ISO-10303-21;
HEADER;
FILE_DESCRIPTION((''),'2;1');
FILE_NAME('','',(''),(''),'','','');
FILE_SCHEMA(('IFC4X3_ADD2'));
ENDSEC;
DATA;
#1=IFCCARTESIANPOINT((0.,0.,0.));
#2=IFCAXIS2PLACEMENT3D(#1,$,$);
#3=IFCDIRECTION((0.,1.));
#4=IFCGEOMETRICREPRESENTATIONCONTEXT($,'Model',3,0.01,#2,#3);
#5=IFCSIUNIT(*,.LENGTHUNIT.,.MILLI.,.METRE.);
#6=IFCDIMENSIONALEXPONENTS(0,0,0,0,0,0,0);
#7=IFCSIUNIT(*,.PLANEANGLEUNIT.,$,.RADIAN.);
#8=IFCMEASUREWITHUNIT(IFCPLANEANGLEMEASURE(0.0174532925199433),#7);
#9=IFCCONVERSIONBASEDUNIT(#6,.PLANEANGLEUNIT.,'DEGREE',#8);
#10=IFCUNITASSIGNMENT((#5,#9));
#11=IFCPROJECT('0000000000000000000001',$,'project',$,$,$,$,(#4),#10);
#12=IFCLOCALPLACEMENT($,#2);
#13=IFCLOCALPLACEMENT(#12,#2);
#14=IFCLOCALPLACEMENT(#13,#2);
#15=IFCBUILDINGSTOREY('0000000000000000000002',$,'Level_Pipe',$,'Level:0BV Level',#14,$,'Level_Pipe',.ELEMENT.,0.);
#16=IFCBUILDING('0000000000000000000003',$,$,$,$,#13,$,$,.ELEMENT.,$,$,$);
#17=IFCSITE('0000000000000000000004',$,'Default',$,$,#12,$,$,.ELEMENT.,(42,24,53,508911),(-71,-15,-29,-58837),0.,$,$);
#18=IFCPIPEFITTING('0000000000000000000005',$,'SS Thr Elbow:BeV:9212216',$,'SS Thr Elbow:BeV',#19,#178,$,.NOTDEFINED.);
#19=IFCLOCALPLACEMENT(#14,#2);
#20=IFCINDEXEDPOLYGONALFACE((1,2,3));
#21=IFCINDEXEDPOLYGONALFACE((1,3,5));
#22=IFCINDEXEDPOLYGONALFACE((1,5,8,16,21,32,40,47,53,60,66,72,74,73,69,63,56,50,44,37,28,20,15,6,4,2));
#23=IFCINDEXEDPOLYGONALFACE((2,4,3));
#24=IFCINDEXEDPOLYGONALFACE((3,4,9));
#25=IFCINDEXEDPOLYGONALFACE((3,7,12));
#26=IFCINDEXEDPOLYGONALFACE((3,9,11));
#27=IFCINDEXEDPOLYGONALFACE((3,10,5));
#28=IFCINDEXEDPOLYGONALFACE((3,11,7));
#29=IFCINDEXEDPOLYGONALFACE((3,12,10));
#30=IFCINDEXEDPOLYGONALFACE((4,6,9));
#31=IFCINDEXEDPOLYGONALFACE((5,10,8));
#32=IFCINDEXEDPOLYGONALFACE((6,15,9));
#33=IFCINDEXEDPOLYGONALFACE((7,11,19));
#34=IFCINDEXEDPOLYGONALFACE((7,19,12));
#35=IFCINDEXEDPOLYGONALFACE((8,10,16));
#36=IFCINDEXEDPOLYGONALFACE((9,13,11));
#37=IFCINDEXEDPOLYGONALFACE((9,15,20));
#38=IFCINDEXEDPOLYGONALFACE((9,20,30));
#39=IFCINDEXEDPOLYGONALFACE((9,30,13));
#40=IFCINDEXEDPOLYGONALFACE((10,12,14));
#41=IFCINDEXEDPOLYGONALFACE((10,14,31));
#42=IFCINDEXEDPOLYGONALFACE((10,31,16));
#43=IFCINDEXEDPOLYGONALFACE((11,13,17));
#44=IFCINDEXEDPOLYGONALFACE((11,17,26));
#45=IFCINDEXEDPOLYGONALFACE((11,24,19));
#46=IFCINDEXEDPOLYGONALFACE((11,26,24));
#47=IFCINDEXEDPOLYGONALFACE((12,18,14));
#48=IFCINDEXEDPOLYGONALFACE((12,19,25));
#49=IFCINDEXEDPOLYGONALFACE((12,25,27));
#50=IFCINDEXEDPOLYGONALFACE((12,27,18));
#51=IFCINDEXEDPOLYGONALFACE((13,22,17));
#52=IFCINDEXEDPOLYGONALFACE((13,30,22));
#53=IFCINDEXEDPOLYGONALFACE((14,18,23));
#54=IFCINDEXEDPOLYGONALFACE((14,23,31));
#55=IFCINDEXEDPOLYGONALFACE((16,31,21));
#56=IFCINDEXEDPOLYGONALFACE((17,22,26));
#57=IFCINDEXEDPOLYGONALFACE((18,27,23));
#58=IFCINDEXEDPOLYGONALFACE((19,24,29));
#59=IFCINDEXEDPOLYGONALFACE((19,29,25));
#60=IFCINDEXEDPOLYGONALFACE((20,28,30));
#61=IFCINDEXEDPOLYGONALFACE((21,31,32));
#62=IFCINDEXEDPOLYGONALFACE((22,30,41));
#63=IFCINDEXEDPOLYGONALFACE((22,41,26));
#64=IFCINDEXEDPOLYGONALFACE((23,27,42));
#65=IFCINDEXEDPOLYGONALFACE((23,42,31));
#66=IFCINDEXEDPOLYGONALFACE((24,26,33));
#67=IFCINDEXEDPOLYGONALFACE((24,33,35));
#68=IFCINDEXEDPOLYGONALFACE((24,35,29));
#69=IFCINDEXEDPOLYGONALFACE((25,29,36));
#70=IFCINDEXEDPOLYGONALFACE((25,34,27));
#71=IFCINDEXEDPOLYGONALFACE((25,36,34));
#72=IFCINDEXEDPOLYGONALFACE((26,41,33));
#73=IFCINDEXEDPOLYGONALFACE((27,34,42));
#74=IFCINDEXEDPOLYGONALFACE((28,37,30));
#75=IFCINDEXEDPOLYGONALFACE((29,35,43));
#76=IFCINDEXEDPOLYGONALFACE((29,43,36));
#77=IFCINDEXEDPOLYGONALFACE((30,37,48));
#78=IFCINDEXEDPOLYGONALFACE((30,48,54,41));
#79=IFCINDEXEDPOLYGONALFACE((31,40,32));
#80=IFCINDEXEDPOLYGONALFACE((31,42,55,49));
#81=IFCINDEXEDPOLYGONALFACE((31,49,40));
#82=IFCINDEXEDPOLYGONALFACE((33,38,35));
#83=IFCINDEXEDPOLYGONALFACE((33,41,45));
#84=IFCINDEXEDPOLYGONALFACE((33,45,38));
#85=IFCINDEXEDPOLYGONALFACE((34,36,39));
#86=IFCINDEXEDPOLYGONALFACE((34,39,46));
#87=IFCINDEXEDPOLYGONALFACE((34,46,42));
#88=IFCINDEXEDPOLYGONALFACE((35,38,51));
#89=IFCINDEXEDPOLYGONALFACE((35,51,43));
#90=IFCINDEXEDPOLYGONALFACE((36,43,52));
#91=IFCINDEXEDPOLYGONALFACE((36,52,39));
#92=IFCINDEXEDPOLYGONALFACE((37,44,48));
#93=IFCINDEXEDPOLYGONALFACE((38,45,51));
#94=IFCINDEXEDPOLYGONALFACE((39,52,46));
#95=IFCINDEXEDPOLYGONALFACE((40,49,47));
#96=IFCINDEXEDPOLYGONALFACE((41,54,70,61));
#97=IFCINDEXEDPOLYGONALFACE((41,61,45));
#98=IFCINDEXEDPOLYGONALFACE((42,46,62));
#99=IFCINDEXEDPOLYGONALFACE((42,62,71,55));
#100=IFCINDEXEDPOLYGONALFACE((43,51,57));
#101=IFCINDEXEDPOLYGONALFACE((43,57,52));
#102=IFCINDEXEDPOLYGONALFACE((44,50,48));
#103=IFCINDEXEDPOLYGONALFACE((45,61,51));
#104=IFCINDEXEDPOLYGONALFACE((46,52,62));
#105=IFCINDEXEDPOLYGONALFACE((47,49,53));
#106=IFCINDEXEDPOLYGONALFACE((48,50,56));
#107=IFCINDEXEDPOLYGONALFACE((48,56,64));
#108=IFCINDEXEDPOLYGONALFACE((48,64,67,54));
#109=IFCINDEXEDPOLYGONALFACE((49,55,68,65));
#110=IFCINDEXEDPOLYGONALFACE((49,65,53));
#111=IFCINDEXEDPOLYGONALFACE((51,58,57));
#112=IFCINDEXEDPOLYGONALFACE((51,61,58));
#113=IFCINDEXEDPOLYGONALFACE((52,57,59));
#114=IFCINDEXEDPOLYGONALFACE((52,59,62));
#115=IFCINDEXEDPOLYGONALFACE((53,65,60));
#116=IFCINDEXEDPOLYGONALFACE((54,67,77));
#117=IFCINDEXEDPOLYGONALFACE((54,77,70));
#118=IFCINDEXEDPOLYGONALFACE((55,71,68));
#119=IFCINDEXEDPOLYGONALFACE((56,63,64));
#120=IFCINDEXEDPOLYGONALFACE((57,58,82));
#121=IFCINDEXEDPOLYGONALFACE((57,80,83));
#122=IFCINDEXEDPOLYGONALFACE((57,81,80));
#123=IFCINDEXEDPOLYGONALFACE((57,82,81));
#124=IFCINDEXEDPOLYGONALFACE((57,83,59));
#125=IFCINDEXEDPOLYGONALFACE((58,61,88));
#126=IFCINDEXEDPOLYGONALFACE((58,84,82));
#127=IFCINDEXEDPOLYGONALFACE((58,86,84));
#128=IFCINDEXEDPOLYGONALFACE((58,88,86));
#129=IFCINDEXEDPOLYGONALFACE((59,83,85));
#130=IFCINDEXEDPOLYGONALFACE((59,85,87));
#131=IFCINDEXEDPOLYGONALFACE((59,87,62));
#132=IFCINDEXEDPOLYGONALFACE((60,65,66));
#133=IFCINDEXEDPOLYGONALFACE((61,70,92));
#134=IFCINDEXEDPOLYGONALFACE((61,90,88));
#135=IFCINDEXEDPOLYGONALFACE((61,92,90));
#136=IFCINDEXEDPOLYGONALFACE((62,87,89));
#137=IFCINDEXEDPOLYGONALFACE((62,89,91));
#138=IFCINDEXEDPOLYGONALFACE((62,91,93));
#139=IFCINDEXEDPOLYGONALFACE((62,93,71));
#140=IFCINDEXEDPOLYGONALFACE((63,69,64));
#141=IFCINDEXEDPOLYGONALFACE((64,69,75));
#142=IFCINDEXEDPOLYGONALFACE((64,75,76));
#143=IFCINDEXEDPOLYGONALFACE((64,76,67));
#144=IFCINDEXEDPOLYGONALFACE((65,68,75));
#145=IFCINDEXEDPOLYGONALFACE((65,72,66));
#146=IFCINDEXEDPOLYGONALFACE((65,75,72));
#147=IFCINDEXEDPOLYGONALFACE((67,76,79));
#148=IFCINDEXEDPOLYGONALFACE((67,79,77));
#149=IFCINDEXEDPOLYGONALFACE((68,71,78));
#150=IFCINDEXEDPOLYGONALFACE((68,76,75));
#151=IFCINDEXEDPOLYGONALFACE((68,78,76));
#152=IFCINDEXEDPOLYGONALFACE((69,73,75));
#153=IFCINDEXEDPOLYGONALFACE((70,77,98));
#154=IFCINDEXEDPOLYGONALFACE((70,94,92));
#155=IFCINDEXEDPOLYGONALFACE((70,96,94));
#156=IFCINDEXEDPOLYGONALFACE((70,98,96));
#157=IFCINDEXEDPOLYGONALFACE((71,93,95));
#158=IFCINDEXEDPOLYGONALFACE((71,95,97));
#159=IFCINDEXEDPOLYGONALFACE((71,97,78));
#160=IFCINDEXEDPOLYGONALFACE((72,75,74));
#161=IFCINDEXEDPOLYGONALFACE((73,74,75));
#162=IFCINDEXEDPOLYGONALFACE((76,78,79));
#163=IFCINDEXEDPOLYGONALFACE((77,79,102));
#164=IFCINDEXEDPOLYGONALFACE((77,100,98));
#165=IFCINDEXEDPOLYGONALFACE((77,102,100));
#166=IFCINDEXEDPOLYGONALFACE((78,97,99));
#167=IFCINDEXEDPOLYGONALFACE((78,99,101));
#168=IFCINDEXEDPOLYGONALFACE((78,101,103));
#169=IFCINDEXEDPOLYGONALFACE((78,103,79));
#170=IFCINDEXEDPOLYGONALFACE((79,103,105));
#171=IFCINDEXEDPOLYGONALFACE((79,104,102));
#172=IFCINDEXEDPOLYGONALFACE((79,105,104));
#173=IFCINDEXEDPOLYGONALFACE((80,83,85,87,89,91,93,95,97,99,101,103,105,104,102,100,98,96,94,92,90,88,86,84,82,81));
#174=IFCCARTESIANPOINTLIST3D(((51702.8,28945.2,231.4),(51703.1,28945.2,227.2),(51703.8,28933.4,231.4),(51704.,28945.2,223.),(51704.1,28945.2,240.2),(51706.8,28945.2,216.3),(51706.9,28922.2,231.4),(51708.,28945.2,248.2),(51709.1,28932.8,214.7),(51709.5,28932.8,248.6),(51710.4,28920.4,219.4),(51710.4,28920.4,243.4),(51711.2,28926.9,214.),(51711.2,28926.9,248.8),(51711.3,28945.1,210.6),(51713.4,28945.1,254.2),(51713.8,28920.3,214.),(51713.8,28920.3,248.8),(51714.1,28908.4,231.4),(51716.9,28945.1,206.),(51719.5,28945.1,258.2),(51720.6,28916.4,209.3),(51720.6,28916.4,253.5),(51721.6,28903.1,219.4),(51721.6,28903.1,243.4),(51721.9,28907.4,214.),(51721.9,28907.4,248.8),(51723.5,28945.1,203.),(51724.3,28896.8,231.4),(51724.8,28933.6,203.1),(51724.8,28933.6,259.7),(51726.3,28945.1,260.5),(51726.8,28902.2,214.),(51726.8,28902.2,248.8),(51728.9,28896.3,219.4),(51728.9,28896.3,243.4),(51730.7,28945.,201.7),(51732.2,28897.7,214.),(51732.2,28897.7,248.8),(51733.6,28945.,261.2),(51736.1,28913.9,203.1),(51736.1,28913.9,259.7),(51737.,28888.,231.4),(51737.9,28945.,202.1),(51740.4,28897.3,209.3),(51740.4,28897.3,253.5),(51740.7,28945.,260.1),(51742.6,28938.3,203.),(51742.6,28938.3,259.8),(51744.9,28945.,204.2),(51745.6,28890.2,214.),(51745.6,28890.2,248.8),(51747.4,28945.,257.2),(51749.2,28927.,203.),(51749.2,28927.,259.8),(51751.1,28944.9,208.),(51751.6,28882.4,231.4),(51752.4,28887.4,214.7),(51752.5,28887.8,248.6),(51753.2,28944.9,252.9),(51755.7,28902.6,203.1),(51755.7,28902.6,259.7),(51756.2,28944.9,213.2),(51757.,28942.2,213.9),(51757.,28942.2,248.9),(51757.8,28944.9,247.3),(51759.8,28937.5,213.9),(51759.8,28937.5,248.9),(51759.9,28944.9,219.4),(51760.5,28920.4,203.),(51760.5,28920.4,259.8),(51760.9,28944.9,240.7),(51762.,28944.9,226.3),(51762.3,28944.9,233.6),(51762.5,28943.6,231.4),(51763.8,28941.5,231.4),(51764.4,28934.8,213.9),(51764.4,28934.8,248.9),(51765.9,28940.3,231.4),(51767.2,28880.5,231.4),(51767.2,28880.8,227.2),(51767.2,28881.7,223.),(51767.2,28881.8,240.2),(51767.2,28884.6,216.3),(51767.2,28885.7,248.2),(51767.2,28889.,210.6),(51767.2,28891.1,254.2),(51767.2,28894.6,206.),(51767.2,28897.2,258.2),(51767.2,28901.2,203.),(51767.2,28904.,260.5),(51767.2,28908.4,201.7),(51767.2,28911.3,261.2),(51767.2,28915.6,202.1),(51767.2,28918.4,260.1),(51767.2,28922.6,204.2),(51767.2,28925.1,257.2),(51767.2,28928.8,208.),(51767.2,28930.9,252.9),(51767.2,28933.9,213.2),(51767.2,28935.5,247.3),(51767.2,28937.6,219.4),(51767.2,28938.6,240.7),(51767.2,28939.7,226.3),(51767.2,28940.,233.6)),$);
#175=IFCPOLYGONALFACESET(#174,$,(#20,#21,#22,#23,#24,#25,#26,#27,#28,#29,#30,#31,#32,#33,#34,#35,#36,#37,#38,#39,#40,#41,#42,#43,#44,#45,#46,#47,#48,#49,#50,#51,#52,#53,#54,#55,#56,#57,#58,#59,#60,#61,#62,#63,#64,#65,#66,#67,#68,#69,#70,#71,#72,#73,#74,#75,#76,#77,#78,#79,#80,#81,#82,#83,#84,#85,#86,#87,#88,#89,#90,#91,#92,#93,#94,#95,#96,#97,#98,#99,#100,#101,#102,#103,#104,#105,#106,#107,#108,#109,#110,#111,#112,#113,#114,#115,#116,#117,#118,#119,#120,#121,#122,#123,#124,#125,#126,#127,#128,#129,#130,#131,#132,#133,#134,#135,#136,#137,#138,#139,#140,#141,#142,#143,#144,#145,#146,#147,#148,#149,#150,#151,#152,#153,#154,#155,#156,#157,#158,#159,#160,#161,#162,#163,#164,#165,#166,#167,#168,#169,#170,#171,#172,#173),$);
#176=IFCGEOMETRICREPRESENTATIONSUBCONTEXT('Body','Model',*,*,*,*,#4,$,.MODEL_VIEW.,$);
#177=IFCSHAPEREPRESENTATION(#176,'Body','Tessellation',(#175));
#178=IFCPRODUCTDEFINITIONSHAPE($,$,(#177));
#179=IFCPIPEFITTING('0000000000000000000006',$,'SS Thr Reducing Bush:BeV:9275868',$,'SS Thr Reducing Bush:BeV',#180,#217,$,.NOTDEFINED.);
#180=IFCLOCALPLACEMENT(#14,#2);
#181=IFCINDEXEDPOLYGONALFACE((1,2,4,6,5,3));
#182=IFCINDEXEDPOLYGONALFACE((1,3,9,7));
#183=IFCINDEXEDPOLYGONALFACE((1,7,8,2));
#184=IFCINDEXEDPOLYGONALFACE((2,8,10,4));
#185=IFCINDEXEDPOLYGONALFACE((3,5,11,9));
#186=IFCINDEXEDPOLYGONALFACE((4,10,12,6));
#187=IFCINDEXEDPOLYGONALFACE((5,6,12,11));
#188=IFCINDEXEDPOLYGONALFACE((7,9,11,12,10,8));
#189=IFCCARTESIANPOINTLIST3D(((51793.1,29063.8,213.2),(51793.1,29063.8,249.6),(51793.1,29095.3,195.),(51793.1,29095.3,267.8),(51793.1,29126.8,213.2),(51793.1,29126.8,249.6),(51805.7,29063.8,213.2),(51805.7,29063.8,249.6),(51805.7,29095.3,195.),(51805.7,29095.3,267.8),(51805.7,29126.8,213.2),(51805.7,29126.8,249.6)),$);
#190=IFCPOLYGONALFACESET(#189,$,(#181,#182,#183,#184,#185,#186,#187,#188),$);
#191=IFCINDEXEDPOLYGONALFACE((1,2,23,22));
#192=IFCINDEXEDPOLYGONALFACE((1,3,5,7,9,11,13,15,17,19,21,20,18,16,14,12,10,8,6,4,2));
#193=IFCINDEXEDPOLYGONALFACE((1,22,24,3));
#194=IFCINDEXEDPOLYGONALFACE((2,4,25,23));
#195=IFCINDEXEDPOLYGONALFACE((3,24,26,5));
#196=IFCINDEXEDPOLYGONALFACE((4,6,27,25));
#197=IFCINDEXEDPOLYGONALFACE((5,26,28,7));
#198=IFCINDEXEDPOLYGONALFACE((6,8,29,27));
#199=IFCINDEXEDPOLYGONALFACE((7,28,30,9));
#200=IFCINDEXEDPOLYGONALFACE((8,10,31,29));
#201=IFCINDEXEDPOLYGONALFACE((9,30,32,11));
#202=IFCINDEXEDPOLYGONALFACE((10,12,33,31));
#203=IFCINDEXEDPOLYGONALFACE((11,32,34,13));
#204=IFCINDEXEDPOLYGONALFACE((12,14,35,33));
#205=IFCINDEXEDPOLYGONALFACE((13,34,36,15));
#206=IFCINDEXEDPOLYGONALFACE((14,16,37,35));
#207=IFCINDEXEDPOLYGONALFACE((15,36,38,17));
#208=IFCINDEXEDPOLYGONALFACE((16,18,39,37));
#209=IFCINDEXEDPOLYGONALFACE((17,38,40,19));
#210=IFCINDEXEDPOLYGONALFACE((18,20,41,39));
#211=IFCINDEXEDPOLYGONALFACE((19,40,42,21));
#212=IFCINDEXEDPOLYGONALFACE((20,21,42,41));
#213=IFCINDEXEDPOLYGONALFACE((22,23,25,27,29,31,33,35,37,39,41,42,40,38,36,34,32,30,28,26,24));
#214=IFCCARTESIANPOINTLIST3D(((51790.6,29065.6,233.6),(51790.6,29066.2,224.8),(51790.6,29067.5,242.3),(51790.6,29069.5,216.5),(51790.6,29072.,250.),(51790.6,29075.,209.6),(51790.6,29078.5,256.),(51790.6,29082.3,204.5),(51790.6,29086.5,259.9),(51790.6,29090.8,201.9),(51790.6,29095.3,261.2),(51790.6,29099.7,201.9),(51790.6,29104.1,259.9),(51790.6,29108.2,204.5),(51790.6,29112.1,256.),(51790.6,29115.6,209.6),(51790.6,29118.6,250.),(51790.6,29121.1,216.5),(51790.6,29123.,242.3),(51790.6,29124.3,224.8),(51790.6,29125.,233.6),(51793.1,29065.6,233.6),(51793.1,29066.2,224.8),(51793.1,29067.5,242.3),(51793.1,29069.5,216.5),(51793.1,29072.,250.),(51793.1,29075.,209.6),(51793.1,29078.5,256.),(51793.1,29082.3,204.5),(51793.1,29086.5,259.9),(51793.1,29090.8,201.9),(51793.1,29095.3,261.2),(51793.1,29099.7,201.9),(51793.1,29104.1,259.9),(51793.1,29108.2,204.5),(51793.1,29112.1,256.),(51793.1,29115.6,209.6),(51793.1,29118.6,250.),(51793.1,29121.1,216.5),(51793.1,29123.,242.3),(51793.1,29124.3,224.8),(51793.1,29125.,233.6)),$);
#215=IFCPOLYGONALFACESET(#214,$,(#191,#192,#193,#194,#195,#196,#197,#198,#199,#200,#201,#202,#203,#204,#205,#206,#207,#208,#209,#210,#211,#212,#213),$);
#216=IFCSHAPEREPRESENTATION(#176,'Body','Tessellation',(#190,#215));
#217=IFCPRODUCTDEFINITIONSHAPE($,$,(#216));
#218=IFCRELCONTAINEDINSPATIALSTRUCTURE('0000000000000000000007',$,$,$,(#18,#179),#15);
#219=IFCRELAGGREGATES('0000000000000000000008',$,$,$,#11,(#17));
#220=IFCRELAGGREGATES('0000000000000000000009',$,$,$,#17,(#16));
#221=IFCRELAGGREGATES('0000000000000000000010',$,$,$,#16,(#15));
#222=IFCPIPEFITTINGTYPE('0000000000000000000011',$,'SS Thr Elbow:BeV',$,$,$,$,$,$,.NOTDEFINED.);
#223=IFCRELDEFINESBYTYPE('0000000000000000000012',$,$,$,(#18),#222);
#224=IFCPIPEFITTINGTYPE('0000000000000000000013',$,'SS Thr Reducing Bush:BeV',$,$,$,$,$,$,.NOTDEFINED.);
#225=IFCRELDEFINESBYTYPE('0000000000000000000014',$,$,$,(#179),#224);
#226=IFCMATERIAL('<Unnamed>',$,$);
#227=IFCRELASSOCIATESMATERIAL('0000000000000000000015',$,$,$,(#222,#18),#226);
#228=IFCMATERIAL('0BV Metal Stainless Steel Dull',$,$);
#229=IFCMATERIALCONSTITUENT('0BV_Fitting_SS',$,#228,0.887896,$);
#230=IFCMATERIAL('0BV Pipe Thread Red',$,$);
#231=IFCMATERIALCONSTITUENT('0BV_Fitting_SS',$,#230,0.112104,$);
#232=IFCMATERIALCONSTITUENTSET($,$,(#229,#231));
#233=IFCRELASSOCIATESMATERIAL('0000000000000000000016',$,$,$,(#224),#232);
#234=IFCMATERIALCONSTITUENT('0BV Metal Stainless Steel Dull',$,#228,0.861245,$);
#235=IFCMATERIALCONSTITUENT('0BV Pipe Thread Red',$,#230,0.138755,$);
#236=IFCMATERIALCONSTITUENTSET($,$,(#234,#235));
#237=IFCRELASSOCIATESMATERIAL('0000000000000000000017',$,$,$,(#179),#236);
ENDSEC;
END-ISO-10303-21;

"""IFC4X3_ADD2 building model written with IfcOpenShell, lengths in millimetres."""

from ifc_helpers import new_model, entity, si_unit, converted_unit, direction, frame, frame_2d, origin, place, context, subcontext, project, spatial, polyline, circle, outline, extrude, source, transform, mapped, material, constituent, constituent_set, type_object, type_shapes, element, save


model = new_model("IFC4X3_ADD2")

# Units and contexts
model_context = context("Model", 3, precision=0.01, world=origin(), true_north=direction((0.0, 1.0)))
body_context = subcontext(model_context, "Body", "Model", "MODEL_VIEW")
ifc_project = project(units=[si_unit("LENGTHUNIT", "METRE", prefix="MILLI"), converted_unit("PLANEANGLEUNIT", "DEGREE", entity("IfcPlaneAngleMeasure", 0.0174532925199433), si_unit("PLANEANGLEUNIT", "RADIAN"), dimensions=[0, 0, 0, 0, 0, 0, 0])], contexts=[model_context])

# Site, building, storey
site_placement = place(None, origin())
site = spatial("IfcSite", under=ifc_project, at=site_placement, Name="Default", CompositionType="ELEMENT", RefLatitude=(42, 24, 53, 508911), RefLongitude=(-71, -15, -29, -58837), RefElevation=0.0)
building_placement = place(site_placement, origin())
building = spatial("IfcBuilding", under=site, at=building_placement, CompositionType="ELEMENT")
storey_placement = place(building_placement, origin())
storey = spatial("IfcBuildingStorey", under=building, at=storey_placement, Name="Level_Pipe", ObjectType="Level:0BV Level", LongName="Level_Pipe", CompositionType="ELEMENT", Elevation=0.0)

# Shared definitions
ifc_material_1 = material(Name="0BV Metal Stainless Steel Dull")
ifc_material_2 = material(Name="0BV Pipe Thread Red")
ifc_material_3 = material(Name="<Unnamed>")

# Pipe fittings
pipe_fitting_type_1 = type_object("IfcPipeFittingType", Name="SS Thr Elbow:BeV", PredefinedType="NOTDEFINED", material=ifc_material_3)
trimmed_curve = entity("IfcTrimmedCurve", entity("IfcCircle", entity("IfcAxis2Placement2D", entity("IfcCartesianPoint", [-4.8, 0.0]), entity("IfcDirection", [0.0, 1.0])), 4.8), [entity("IfcParameterValue", 270.0)], [entity("IfcParameterValue", 0.0)], True, "PARAMETER")
shared_shape_1 = source(origin(), body_context, "Body", "AdvancedSweptSolid", [
    entity("IfcSurfaceCurveSweptAreaSolid", entity("IfcCircleProfileDef", "AREA", None, entity("IfcAxis2Placement2D", entity("IfcCartesianPoint", [29.8, 0.0]), entity("IfcDirection", [1.0, 0.0])), 29.8), entity("IfcAxis2Placement3D", entity("IfcCartesianPoint", [-29.8, 34.6, 0.0]), entity("IfcDirection", [0.0, 0.0, -1.0]), entity("IfcDirection", [1.0, 0.0, 0.0])), trimmed_curve, entity("IfcParameterValue", 0.0), entity("IfcParameterValue", 90.0), entity("IfcSurfaceOfLinearExtrusion", entity("IfcArbitraryOpenProfileDef", "CURVE", None, trimmed_curve), entity("IfcAxis2Placement3D", entity("IfcCartesianPoint", [0.0, 0.0, -304.8])), entity("IfcDirection", [0.0, 0.0, 1.0]), 1.0)),
])
type_shapes(pipe_fitting_type_1, [shared_shape_1])
pipe_fitting_1_placement = place(storey_placement, frame((51732.6, 28910.3, 231.4), z_axis=(0.0, -0.000012, 1.0), x_axis=(0.0, -1.0, -0.000012)))
element("IfcPipeFitting", 1, at=pipe_fitting_1_placement, inside=storey, type_object=pipe_fitting_type_1, material=ifc_material_3, Name="SS Thr Elbow:BeV:9212216", ObjectType="SS Thr Elbow:BeV", PredefinedType="NOTDEFINED", context=body_context, shape_type="MappedRepresentation", body=[
    mapped(shared_shape_1, transform((0.0, 0.0, 0.0), scale=1.0)),
])
ifc_constituent_1 = constituent(ifc_material_1, Name="0BV Metal Stainless Steel Dull", fraction=0.861245)
ifc_constituent_2 = constituent(ifc_material_2, Name="0BV Pipe Thread Red", fraction=0.138755)
ifc_constituent_set_1 = constituent_set(constituents=[ifc_constituent_1, ifc_constituent_2])
ifc_constituent_3 = constituent(ifc_material_1, Name="0BV_Fitting_SS", fraction=0.887896)
ifc_constituent_4 = constituent(ifc_material_2, Name="0BV_Fitting_SS", fraction=0.112104)
ifc_constituent_set_2 = constituent_set(constituents=[ifc_constituent_3, ifc_constituent_4])
pipe_fitting_type_2 = type_object("IfcPipeFittingType", Name="SS Thr Reducing Bush:BeV", PredefinedType="NOTDEFINED", material=ifc_constituent_set_2)
shared_shape_2 = source(origin(), body_context, "Body", "SweptSolid", [
    extrude(outline(polyline([(-18.2, -31.5), (18.2, -31.5), (36.4, 0.0), (18.2, 31.5), (-18.2, 31.5), (-36.4, 0.0), (-18.2, -31.5)])), frame((2.5, 36.4, 31.5), z_axis=(1.0, 0.0, 0.0), x_axis=(0.0, -1.0, 0.0)), (0.0, 0.0, 1.0), 12.6),
    extrude(circle(Radius=29.8, at=frame_2d((0.0, 0.0), x_axis=(1.0, 0.0))), frame((0.0, 36.4, 31.5), z_axis=(1.0, 0.0, 0.0), x_axis=(0.0, -1.0, 0.0)), (0.0, 0.0, 1.0), 2.5),
])
type_shapes(pipe_fitting_type_2, [shared_shape_2])
pipe_fitting_2_placement = place(storey_placement, frame((51790.6, 29063.8, 267.8), z_axis=(0.0, 1.0, -0.000003), x_axis=(1.0, 0.0, 0.0)))
element("IfcPipeFitting", 2, at=pipe_fitting_2_placement, inside=storey, type_object=pipe_fitting_type_2, material=ifc_constituent_set_1, Name="SS Thr Reducing Bush:BeV:9275868", ObjectType="SS Thr Reducing Bush:BeV", PredefinedType="NOTDEFINED", context=body_context, shape_type="MappedRepresentation", body=[
    mapped(shared_shape_2, transform((0.0, 0.0, 0.0), scale=1.0)),
])

save(model, "model.ifc")
